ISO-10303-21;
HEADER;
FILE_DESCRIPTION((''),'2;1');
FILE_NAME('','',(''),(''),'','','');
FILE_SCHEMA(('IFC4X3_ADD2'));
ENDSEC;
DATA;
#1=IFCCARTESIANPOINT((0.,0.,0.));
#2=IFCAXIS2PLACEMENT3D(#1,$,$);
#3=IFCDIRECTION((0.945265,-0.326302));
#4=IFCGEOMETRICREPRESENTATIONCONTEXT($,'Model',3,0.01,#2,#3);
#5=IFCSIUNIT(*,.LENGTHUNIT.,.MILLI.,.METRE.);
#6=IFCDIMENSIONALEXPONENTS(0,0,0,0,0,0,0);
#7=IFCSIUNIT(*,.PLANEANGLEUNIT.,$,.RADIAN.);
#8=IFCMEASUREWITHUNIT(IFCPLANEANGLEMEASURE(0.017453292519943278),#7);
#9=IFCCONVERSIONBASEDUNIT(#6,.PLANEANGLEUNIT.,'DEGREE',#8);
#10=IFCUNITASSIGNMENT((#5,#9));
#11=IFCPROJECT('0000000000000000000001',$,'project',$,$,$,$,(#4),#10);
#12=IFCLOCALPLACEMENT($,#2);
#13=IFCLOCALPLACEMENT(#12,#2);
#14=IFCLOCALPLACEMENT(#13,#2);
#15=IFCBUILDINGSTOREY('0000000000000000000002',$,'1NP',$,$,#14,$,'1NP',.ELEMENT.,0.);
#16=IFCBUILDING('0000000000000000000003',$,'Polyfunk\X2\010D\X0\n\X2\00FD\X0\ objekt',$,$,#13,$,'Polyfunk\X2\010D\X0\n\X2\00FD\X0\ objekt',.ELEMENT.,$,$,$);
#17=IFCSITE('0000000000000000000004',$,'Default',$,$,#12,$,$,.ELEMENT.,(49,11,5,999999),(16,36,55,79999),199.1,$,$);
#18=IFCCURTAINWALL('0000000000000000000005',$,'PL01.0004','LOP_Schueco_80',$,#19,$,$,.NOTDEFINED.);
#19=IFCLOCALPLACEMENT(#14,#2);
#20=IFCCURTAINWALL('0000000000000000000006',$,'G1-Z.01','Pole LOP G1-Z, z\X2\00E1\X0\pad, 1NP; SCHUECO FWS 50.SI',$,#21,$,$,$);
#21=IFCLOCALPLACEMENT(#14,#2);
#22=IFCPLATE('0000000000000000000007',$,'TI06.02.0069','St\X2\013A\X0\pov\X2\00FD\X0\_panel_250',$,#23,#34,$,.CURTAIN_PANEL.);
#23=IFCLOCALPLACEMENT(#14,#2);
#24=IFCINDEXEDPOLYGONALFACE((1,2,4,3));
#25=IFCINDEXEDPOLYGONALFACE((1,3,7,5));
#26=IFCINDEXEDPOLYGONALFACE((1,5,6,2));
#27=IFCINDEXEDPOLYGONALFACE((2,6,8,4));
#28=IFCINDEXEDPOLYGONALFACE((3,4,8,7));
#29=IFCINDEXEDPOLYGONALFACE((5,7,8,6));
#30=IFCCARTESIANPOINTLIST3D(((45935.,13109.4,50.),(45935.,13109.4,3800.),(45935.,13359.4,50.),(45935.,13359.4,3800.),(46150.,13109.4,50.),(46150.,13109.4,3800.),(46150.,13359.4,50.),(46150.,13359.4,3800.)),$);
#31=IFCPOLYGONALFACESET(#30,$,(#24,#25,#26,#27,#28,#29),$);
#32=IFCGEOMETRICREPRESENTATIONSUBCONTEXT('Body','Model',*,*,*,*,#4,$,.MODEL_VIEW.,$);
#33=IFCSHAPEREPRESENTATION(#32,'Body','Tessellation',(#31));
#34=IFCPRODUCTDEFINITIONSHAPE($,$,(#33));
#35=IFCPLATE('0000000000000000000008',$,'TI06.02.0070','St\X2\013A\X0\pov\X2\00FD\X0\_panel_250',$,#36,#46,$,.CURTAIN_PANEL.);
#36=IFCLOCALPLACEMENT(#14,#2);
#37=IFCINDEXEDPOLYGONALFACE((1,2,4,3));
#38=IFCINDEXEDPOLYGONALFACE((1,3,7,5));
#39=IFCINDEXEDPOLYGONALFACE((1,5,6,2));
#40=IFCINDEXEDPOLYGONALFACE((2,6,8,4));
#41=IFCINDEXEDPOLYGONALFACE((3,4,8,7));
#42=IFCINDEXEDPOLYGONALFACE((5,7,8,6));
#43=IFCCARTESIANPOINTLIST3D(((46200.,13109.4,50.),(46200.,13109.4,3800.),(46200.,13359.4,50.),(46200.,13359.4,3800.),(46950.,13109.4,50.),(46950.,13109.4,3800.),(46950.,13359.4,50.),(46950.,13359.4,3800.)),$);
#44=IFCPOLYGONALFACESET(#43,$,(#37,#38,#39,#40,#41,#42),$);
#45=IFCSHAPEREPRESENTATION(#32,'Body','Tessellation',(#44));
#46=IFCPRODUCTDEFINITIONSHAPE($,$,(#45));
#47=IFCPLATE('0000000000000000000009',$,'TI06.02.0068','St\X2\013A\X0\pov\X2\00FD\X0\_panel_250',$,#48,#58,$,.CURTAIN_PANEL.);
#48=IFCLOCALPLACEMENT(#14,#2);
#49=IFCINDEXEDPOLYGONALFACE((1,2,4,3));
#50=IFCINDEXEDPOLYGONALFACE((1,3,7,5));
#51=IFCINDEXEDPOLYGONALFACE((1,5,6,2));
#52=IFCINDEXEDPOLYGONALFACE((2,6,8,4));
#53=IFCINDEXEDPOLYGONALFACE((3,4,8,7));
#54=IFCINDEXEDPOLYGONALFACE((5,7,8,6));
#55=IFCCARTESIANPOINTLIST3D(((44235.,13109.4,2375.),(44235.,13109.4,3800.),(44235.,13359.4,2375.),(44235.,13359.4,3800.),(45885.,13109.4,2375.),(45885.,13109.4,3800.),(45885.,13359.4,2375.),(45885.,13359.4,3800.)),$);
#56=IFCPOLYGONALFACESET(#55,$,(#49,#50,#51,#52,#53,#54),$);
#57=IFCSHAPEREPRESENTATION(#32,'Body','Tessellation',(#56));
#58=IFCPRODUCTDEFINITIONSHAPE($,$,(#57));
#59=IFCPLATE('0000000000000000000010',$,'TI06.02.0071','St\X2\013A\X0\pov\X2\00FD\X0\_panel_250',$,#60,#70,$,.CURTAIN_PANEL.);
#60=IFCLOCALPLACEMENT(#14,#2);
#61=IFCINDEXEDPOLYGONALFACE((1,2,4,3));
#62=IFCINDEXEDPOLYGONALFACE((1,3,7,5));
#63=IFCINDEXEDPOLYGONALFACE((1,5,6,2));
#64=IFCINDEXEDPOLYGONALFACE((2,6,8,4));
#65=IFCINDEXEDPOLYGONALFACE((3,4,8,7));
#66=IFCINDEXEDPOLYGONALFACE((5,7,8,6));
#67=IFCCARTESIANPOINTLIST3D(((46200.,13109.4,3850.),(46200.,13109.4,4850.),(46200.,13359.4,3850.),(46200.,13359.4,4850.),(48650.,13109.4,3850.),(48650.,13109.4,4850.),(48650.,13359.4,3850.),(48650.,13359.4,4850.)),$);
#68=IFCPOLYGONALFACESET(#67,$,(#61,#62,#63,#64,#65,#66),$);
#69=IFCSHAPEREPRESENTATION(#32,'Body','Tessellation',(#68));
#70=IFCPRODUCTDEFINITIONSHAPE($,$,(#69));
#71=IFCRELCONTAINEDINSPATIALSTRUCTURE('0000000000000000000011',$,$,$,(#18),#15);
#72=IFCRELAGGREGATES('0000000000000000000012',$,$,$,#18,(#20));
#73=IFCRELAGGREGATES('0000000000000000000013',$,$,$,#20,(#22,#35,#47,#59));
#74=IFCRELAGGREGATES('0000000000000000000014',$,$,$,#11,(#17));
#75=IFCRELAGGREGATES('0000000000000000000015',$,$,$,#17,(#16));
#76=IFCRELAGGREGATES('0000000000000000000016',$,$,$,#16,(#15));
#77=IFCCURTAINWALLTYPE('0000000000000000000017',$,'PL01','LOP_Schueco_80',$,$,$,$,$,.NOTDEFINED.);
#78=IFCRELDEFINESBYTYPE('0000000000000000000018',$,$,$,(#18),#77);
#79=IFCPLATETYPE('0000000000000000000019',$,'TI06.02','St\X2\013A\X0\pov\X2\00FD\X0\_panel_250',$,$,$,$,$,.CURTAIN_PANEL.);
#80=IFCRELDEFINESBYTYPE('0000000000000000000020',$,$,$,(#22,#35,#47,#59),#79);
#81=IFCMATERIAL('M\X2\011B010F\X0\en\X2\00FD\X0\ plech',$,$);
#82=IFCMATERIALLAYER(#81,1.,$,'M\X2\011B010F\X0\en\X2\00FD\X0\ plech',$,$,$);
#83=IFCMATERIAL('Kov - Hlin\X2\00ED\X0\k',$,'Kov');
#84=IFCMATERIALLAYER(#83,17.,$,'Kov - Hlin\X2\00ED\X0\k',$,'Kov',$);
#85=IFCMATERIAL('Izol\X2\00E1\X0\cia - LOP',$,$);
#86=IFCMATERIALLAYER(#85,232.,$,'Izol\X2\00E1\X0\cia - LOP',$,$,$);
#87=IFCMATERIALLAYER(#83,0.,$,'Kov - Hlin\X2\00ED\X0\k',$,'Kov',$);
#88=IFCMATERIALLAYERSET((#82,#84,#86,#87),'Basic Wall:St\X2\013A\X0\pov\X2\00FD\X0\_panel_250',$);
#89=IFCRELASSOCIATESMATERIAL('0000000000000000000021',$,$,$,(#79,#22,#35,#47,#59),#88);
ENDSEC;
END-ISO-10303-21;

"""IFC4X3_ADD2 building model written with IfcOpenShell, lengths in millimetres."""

from ifc_helpers import new_model, entity, si_unit, converted_unit, direction, frame, frame_2d, origin, place, context, subcontext, project, spatial, rectangle, extrude, material, layer, layer_set, layer_usage, type_object, element, aggregate, save


model = new_model("IFC4X3_ADD2")

# Units and contexts
model_context = context("Model", 3, precision=0.01, world=origin(), true_north=direction((0.945265, -0.326302)))
body_context = subcontext(model_context, "Body", "Model", "MODEL_VIEW")
ifc_project = project(units=[si_unit("LENGTHUNIT", "METRE", prefix="MILLI"), converted_unit("PLANEANGLEUNIT", "DEGREE", entity("IfcPlaneAngleMeasure", 0.017453292519943278), si_unit("PLANEANGLEUNIT", "RADIAN"), dimensions=[0, 0, 0, 0, 0, 0, 0])], contexts=[model_context])

# Site, building, storey
site_placement = place(None, origin())
site = spatial("IfcSite", under=ifc_project, at=site_placement, Name="Default", CompositionType="ELEMENT", RefLatitude=(49, 11, 5, 999999), RefLongitude=(16, 36, 55, 79999), RefElevation=199.1)
building_placement = place(site_placement, origin())
building = spatial("IfcBuilding", under=site, at=building_placement, Name="Polyfunkčný objekt", LongName="Polyfunkčný objekt", CompositionType="ELEMENT")
storey_placement = place(building_placement, origin())
storey = spatial("IfcBuildingStorey", under=building, at=storey_placement, Name="1NP", LongName="1NP", CompositionType="ELEMENT", Elevation=0.0)

# Curtain walls, plates
curtain_wall_type = type_object("IfcCurtainWallType", Name="PL01", Description="LOP_Schueco_80", PredefinedType="NOTDEFINED")
curtain_wall_1_placement = place(storey_placement, origin())
curtain_wall_1 = element("IfcCurtainWall", 1, at=curtain_wall_1_placement, inside=storey, type_object=curtain_wall_type, Name="PL01.0004", Description="LOP_Schueco_80", PredefinedType="NOTDEFINED")
curtain_wall_2 = element("IfcCurtainWall", 2, Name="G1-Z.01", Description="Pole LOP G1-Z, západ, 1NP; SCHUECO FWS 50.SI")
aggregate(curtain_wall_1, [curtain_wall_2])
ifc_material_1 = material(Name="Měďený plech")
ifc_layer_1 = layer(ifc_material_1, 1.0, Name="Měďený plech")
ifc_material_2 = material(Name="Kov - Hliník", Category="Kov")
ifc_layer_2 = layer(ifc_material_2, 17.0, Name="Kov - Hliník", Category="Kov")
ifc_material_3 = material(Name="Izolácia - LOP")
ifc_layer_3 = layer(ifc_material_3, 232.0, Name="Izolácia - LOP")
ifc_layer_4 = layer(ifc_material_2, 0.0, Name="Kov - Hliník", Category="Kov")
ifc_layer_set = layer_set([ifc_layer_1, ifc_layer_2, ifc_layer_3, ifc_layer_4], Name="Basic Wall:Stĺpový_panel_250")
ifc_layer_usage_1 = layer_usage(ifc_layer_set, "AXIS2", "NEGATIVE", 125.0)
plate_type = type_object("IfcPlateType", Name="TI06.02", Description="Stĺpový_panel_250", PredefinedType="CURTAIN_PANEL", material=ifc_layer_set)
plate_1_placement = place(storey_placement, frame((45935.0, 13234.4, 50.0)))
plate_1 = element("IfcPlate", 3, at=plate_1_placement, type_object=plate_type, material=ifc_layer_usage_1, Name="TI06.02.0069", Description="Stĺpový_panel_250", PredefinedType="CURTAIN_PANEL", context=body_context, shape_type="SweptSolid", body=[
    extrude(rectangle(XDim=250.0, YDim=215.0, at=frame_2d((0.0, 0.0), x_axis=(1.0, 0.0))), frame((107.5, 0.0, 0.0), z_axis=(0.0, 0.0, 1.0), x_axis=(0.0, 1.0, 0.0)), (0.0, 0.0, 1.0), 3750.0),
])
ifc_layer_usage_2 = layer_usage(ifc_layer_set, "AXIS2", "NEGATIVE", 125.0)
plate_2_placement = place(storey_placement, frame((46200.0, 13234.4, 50.0)))
plate_2 = element("IfcPlate", 4, at=plate_2_placement, type_object=plate_type, material=ifc_layer_usage_2, Name="TI06.02.0070", Description="Stĺpový_panel_250", PredefinedType="CURTAIN_PANEL", context=body_context, shape_type="SweptSolid", body=[
    extrude(rectangle(XDim=250.0, YDim=750.0, at=frame_2d((0.0, 0.0), x_axis=(1.0, 0.0))), frame((375.0, 0.0, 0.0), z_axis=(0.0, 0.0, 1.0), x_axis=(0.0, 1.0, 0.0)), (0.0, 0.0, 1.0), 3750.0),
])
ifc_layer_usage_3 = layer_usage(ifc_layer_set, "AXIS2", "NEGATIVE", 125.0)
plate_3_placement = place(storey_placement, frame((44235.0, 13234.4, 2375.0)))
plate_3 = element("IfcPlate", 5, at=plate_3_placement, type_object=plate_type, material=ifc_layer_usage_3, Name="TI06.02.0068", Description="Stĺpový_panel_250", PredefinedType="CURTAIN_PANEL", context=body_context, shape_type="SweptSolid", body=[
    extrude(rectangle(XDim=250.0, YDim=1650.0, at=frame_2d((0.0, 0.0), x_axis=(1.0, 0.0))), frame((825.0, 0.0, 0.0), z_axis=(0.0, 0.0, 1.0), x_axis=(0.0, 1.0, 0.0)), (0.0, 0.0, 1.0), 1425.0),
])
ifc_layer_usage_4 = layer_usage(ifc_layer_set, "AXIS2", "NEGATIVE", 125.0)
plate_4_placement = place(storey_placement, frame((46200.0, 13234.4, 3850.0)))
plate_4 = element("IfcPlate", 6, at=plate_4_placement, type_object=plate_type, material=ifc_layer_usage_4, Name="TI06.02.0071", Description="Stĺpový_panel_250", PredefinedType="CURTAIN_PANEL", context=body_context, shape_type="SweptSolid", body=[
    extrude(rectangle(XDim=250.0, YDim=2450.0, at=frame_2d((0.0, 0.0), x_axis=(1.0, 0.0))), frame((1225.0, 0.0, 0.0), z_axis=(0.0, 0.0, 1.0), x_axis=(0.0, 1.0, 0.0)), (0.0, 0.0, 1.0), 1000.0),
])
aggregate(curtain_wall_2, [plate_1, plate_2, plate_3, plate_4])

save(model, "model.ifc")
